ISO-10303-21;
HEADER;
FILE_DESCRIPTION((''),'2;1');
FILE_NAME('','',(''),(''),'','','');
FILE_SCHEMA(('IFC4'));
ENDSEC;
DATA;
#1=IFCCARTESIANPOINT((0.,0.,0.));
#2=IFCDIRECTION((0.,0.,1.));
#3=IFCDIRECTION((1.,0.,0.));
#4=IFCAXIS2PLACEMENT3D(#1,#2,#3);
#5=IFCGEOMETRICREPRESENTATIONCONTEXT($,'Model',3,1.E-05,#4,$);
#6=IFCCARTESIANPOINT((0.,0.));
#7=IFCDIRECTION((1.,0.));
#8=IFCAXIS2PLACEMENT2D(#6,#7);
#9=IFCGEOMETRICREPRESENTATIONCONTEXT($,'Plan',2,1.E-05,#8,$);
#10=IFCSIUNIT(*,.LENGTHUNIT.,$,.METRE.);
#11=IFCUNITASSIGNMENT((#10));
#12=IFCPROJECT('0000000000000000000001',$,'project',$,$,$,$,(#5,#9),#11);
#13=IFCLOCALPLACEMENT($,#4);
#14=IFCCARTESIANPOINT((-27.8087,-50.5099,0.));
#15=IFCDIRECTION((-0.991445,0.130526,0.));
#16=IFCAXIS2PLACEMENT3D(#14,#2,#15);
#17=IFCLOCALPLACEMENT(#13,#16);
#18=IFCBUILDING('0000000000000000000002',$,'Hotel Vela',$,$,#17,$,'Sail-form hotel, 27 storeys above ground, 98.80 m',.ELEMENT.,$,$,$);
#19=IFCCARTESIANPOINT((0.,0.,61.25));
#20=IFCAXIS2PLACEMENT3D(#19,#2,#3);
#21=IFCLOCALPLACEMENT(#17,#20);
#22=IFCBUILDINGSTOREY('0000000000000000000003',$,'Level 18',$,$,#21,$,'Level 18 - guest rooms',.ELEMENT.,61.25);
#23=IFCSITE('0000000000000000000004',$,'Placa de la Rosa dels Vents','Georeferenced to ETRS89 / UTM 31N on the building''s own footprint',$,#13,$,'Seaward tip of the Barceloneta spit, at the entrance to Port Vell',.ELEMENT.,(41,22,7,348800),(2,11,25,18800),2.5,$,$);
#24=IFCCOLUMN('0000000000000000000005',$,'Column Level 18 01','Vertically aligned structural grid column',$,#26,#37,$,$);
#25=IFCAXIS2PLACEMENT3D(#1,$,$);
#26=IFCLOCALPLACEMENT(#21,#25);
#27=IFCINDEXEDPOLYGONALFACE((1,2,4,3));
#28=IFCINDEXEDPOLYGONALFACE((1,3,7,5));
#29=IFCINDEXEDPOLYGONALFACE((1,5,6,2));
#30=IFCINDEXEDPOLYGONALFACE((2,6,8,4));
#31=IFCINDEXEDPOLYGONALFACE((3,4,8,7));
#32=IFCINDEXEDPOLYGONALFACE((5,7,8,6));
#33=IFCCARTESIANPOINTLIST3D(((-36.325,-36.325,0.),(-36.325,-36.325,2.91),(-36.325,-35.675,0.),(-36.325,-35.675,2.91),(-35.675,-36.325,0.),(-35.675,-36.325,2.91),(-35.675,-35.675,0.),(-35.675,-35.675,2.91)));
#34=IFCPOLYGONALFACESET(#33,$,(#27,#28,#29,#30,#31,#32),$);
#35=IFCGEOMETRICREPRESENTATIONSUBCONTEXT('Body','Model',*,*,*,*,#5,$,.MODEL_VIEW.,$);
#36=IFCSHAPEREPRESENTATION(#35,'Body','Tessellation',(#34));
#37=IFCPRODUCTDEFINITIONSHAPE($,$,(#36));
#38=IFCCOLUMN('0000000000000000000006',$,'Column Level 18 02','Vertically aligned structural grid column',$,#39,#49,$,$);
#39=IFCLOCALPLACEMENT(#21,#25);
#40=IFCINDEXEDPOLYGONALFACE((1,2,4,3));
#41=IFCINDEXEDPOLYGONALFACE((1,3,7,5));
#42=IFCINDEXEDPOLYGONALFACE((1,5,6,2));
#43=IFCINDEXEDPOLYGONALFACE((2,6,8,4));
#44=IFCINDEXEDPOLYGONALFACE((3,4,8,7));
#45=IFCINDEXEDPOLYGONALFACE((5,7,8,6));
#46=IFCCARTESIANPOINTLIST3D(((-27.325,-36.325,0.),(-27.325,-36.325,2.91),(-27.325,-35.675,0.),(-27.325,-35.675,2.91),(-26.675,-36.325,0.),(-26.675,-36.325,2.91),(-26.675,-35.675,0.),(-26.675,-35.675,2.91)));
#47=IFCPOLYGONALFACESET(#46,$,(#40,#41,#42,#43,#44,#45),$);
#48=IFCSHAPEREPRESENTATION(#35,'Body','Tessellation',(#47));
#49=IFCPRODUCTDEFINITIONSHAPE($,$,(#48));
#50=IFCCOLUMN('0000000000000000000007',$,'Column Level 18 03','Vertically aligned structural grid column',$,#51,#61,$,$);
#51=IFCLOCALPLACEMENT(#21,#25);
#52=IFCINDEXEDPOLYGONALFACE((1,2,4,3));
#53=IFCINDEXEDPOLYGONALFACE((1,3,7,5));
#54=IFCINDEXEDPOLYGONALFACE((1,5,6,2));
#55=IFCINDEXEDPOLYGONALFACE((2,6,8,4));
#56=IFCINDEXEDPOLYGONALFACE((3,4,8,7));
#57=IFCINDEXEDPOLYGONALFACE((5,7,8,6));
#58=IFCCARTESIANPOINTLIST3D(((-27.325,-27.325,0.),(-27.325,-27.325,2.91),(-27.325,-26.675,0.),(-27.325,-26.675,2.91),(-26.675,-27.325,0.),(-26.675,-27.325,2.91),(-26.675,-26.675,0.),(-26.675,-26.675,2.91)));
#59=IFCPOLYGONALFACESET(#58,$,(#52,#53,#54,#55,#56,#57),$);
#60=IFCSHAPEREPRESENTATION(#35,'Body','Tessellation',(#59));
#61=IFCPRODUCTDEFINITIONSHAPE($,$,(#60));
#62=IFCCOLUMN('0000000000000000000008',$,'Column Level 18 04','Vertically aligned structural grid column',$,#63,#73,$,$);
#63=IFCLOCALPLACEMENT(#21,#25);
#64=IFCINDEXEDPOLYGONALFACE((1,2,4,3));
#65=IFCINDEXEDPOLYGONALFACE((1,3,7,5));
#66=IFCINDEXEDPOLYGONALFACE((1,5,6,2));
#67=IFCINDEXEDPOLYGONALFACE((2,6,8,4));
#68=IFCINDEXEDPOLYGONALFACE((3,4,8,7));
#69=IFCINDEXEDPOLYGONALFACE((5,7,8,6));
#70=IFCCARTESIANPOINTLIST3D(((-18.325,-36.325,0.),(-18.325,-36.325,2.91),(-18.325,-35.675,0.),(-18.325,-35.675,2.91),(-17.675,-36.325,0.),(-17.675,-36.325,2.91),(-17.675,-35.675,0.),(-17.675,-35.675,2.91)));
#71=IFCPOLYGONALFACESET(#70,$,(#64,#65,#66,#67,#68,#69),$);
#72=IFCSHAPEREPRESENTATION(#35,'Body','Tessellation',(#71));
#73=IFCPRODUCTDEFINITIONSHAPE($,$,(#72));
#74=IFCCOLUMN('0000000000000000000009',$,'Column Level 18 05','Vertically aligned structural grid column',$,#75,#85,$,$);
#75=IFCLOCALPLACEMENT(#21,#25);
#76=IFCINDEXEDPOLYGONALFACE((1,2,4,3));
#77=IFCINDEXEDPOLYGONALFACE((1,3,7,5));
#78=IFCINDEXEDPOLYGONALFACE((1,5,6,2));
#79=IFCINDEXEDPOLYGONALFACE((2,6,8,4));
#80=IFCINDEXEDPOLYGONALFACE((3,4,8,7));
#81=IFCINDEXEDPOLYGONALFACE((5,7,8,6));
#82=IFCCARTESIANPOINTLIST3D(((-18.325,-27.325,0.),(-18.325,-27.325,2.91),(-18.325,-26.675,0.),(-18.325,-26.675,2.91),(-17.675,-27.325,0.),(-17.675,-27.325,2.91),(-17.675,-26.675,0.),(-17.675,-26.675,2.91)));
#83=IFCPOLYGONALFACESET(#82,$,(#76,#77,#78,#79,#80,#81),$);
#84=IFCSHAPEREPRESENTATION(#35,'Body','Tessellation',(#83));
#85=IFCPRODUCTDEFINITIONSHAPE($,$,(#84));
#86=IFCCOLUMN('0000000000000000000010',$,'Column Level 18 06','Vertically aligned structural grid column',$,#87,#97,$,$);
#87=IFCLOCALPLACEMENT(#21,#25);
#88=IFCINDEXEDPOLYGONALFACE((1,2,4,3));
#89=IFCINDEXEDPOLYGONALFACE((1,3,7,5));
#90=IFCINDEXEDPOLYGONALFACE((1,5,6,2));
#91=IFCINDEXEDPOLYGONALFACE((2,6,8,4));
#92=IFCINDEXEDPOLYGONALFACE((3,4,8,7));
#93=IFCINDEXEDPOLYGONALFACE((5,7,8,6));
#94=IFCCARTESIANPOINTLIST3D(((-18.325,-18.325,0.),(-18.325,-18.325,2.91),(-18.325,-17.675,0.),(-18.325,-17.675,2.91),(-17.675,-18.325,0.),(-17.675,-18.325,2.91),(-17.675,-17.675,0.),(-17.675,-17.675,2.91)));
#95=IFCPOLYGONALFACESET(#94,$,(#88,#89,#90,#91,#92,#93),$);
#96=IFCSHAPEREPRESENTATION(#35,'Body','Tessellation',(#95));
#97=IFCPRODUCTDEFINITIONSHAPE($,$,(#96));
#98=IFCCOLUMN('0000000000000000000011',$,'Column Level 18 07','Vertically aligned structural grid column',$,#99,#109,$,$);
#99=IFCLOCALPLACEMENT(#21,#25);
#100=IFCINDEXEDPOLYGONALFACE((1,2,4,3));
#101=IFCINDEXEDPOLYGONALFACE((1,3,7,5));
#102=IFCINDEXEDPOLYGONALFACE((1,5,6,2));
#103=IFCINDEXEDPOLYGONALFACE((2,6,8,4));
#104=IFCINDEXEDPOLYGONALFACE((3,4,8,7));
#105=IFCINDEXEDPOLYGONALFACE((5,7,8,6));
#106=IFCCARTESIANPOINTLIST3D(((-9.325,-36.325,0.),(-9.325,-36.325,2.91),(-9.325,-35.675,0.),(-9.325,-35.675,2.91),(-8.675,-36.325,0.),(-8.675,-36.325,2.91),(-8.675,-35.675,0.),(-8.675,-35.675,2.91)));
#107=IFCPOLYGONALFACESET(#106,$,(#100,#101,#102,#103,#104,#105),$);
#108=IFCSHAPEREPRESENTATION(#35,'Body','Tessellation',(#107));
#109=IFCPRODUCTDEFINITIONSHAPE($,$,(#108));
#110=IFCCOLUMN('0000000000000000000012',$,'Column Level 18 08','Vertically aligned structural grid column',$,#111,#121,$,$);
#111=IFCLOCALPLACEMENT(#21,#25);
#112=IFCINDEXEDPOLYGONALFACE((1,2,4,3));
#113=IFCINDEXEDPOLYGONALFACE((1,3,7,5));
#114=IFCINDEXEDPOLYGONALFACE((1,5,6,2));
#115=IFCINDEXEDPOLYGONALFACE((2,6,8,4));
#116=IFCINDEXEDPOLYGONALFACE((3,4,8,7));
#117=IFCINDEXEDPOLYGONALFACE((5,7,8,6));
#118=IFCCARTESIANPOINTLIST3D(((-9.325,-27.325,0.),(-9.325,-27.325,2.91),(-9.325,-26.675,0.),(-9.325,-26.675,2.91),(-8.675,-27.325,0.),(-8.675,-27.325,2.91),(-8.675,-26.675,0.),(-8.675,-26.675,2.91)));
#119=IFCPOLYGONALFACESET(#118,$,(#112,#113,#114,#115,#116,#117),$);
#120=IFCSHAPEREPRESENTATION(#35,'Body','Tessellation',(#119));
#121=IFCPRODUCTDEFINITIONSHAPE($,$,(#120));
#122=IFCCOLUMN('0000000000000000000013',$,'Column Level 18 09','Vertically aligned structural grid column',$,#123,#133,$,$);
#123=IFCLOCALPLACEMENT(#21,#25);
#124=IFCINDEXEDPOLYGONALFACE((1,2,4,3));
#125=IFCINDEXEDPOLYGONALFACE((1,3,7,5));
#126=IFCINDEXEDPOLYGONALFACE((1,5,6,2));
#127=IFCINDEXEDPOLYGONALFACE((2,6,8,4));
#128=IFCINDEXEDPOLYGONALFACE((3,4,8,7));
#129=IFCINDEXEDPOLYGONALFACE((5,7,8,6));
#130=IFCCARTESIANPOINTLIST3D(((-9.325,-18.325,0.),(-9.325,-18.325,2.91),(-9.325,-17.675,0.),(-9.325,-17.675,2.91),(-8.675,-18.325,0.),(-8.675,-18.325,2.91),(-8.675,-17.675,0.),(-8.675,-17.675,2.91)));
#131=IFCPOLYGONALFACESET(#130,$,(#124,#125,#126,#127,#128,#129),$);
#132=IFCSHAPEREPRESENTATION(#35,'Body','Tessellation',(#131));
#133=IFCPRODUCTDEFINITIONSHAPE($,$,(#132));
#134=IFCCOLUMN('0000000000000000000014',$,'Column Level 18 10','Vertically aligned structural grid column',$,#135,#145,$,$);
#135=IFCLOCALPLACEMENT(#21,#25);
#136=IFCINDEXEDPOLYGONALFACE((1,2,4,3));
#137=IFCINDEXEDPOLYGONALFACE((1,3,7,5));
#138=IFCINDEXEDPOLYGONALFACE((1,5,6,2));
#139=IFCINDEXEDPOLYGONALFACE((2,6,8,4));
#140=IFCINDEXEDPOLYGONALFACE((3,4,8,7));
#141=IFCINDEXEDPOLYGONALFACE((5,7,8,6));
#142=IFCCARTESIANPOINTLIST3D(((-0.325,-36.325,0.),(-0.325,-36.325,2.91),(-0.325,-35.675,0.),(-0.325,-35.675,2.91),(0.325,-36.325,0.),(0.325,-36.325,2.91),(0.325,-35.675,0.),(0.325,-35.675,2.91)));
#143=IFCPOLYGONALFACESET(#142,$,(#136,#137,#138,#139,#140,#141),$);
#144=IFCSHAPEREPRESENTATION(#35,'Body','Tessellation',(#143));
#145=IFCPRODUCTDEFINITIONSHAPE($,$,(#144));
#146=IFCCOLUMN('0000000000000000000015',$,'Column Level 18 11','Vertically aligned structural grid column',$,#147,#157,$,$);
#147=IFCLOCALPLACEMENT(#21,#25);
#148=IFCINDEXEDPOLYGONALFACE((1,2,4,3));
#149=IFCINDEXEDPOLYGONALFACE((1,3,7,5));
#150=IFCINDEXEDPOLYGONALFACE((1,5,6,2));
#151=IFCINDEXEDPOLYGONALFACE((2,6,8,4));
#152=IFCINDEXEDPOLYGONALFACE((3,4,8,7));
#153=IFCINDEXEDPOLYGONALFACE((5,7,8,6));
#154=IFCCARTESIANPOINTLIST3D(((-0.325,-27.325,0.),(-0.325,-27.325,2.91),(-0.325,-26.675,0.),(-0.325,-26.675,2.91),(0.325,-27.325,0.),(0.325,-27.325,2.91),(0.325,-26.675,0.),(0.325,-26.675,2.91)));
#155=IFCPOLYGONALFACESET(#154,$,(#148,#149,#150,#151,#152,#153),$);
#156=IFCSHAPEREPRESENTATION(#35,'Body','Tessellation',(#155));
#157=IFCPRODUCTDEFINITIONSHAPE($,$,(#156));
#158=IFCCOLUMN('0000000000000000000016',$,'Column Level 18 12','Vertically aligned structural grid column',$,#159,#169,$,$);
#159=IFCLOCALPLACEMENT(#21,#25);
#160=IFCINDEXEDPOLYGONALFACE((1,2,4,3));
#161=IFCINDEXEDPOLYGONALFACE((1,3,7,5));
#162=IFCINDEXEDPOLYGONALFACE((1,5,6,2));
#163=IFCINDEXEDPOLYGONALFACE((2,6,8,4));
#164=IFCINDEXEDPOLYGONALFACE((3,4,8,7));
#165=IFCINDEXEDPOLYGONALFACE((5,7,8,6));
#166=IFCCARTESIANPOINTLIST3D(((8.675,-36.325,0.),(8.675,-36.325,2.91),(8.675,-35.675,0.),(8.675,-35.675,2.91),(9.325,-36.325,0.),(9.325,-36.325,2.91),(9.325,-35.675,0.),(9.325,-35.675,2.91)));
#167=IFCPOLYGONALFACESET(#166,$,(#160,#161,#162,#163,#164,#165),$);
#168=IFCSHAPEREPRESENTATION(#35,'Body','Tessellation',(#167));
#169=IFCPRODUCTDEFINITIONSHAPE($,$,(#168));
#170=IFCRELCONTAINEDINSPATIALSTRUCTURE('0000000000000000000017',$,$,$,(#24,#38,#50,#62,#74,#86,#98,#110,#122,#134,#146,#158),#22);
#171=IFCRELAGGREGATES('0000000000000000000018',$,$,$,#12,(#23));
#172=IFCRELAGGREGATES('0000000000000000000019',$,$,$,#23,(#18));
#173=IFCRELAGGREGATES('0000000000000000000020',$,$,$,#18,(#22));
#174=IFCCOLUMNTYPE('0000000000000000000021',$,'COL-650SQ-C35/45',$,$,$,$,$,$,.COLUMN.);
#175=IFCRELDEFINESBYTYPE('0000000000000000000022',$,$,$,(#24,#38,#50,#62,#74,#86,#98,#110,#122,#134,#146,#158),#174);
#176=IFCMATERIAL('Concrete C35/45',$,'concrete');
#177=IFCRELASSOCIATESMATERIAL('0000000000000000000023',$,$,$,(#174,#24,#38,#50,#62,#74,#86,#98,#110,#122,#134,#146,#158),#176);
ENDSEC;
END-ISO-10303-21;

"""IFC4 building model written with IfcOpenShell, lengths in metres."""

from ifc_helpers import new_model, si_unit, frame, origin_with_axes, origin_2d_with_axis, place, context, subcontext, project, spatial, line, indexed_curve, rectangle, outline, extrude, material, material_profile, profile_set, profile_usage, type_object, element, save


model = new_model("IFC4")

# Units and contexts
model_context = context("Model", 3, precision=1e-05, world=origin_with_axes())
plan_context = context("Plan", 2, precision=1e-05, world=origin_2d_with_axis())
body_context = subcontext(model_context, "Body", "Model", "MODEL_VIEW")
ifc_project = project(units=[si_unit("LENGTHUNIT", "METRE")], contexts=[model_context, plan_context])

# Site, building, storey
site_placement = place(None, origin_with_axes())
site = spatial("IfcSite", under=ifc_project, at=site_placement, Name="Placa de la Rosa dels Vents", Description="Georeferenced to ETRS89 / UTM 31N on the building's own footprint", LongName="Seaward tip of the Barceloneta spit, at the entrance to Port Vell", CompositionType="ELEMENT", RefLatitude=(41, 22, 7, 348800), RefLongitude=(2, 11, 25, 18800), RefElevation=2.5)
building_placement = place(site_placement, frame((-27.8087, -50.5099, 0.0), z_axis=(0.0, 0.0, 1.0), x_axis=(-0.991445, 0.130526, 0.0)))
building = spatial("IfcBuilding", under=site, at=building_placement, Name="Hotel Vela", LongName="Sail-form hotel, 27 storeys above ground, 98.80 m", CompositionType="ELEMENT")
storey_placement = place(building_placement, frame((0.0, 0.0, 61.25), z_axis=(0.0, 0.0, 1.0), x_axis=(1.0, 0.0, 0.0)))
storey = spatial("IfcBuildingStorey", under=building, at=storey_placement, Name="Level 18", LongName="Level 18 - guest rooms", CompositionType="ELEMENT", Elevation=61.25)

# Columns
ifc_material = material(Name="Concrete C35/45", Category="concrete")
ifc_material_profile = material_profile(ifc_material, rectangle(XDim=0.65, YDim=0.65))
ifc_profile_set = profile_set([ifc_material_profile], Name="COL-650SQ-C35/45")
ifc_profile_usage_1 = profile_usage(ifc_profile_set)
column_type = type_object("IfcColumnType", Name="COL-650SQ-C35/45", PredefinedType="COLUMN", material=ifc_profile_set)
column_1_placement = place(storey_placement, frame((-36.325, -36.325, 0.0), z_axis=(0.0, 0.0, 1.0), x_axis=(1.0, 0.0, 0.0)))
element("IfcColumn", 1, at=column_1_placement, inside=storey, type_object=column_type, material=ifc_profile_usage_1, Name="Column Level 18 01", Description="Vertically aligned structural grid column", context=body_context, shape_type="SweptSolid", body=[
    extrude(outline(indexed_curve([(0.0, 0.0), (0.65, 0.0), (0.65, 0.65), (0.0, 0.65)], segments=[line(1, 2, 3, 4, 1)])), origin_with_axes(), (0.0, 0.0, 1.0), 2.91),
])
ifc_profile_usage_2 = profile_usage(ifc_profile_set)
column_2_placement = place(storey_placement, frame((-27.325, -36.325, 0.0), z_axis=(0.0, 0.0, 1.0), x_axis=(1.0, 0.0, 0.0)))
element("IfcColumn", 2, at=column_2_placement, inside=storey, type_object=column_type, material=ifc_profile_usage_2, Name="Column Level 18 02", Description="Vertically aligned structural grid column", context=body_context, shape_type="SweptSolid", body=[
    extrude(outline(indexed_curve([(0.0, 0.0), (0.65, 0.0), (0.65, 0.65), (0.0, 0.65)], segments=[line(1, 2, 3, 4, 1)])), origin_with_axes(), (0.0, 0.0, 1.0), 2.91),
])
ifc_profile_usage_3 = profile_usage(ifc_profile_set)
column_3_placement = place(storey_placement, frame((-27.325, -27.325, 0.0), z_axis=(0.0, 0.0, 1.0), x_axis=(1.0, 0.0, 0.0)))
element("IfcColumn", 3, at=column_3_placement, inside=storey, type_object=column_type, material=ifc_profile_usage_3, Name="Column Level 18 03", Description="Vertically aligned structural grid column", context=body_context, shape_type="SweptSolid", body=[
    extrude(outline(indexed_curve([(0.0, 0.0), (0.65, 0.0), (0.65, 0.65), (0.0, 0.65)], segments=[line(1, 2, 3, 4, 1)])), origin_with_axes(), (0.0, 0.0, 1.0), 2.91),
])
ifc_profile_usage_4 = profile_usage(ifc_profile_set)
column_4_placement = place(storey_placement, frame((-18.325, -36.325, 0.0), z_axis=(0.0, 0.0, 1.0), x_axis=(1.0, 0.0, 0.0)))
element("IfcColumn", 4, at=column_4_placement, inside=storey, type_object=column_type, material=ifc_profile_usage_4, Name="Column Level 18 04", Description="Vertically aligned structural grid column", context=body_context, shape_type="SweptSolid", body=[
    extrude(outline(indexed_curve([(0.0, 0.0), (0.65, 0.0), (0.65, 0.65), (0.0, 0.65)], segments=[line(1, 2, 3, 4, 1)])), origin_with_axes(), (0.0, 0.0, 1.0), 2.91),
])
ifc_profile_usage_5 = profile_usage(ifc_profile_set)
column_5_placement = place(storey_placement, frame((-18.325, -27.325, 0.0), z_axis=(0.0, 0.0, 1.0), x_axis=(1.0, 0.0, 0.0)))
element("IfcColumn", 5, at=column_5_placement, inside=storey, type_object=column_type, material=ifc_profile_usage_5, Name="Column Level 18 05", Description="Vertically aligned structural grid column", context=body_context, shape_type="SweptSolid", body=[
    extrude(outline(indexed_curve([(0.0, 0.0), (0.65, 0.0), (0.65, 0.65), (0.0, 0.65)], segments=[line(1, 2, 3, 4, 1)])), origin_with_axes(), (0.0, 0.0, 1.0), 2.91),
])
ifc_profile_usage_6 = profile_usage(ifc_profile_set)
column_6_placement = place(storey_placement, frame((-18.325, -18.325, 0.0), z_axis=(0.0, 0.0, 1.0), x_axis=(1.0, 0.0, 0.0)))
element("IfcColumn", 6, at=column_6_placement, inside=storey, type_object=column_type, material=ifc_profile_usage_6, Name="Column Level 18 06", Description="Vertically aligned structural grid column", context=body_context, shape_type="SweptSolid", body=[
    extrude(outline(indexed_curve([(0.0, 0.0), (0.65, 0.0), (0.65, 0.65), (0.0, 0.65)], segments=[line(1, 2, 3, 4, 1)])), origin_with_axes(), (0.0, 0.0, 1.0), 2.91),
])
ifc_profile_usage_7 = profile_usage(ifc_profile_set)
column_7_placement = place(storey_placement, frame((-9.325, -36.325, 0.0), z_axis=(0.0, 0.0, 1.0), x_axis=(1.0, 0.0, 0.0)))
element("IfcColumn", 7, at=column_7_placement, inside=storey, type_object=column_type, material=ifc_profile_usage_7, Name="Column Level 18 07", Description="Vertically aligned structural grid column", context=body_context, shape_type="SweptSolid", body=[
    extrude(outline(indexed_curve([(0.0, 0.0), (0.65, 0.0), (0.65, 0.65), (0.0, 0.65)], segments=[line(1, 2, 3, 4, 1)])), origin_with_axes(), (0.0, 0.0, 1.0), 2.91),
])
ifc_profile_usage_8 = profile_usage(ifc_profile_set)
column_8_placement = place(storey_placement, frame((-9.325, -27.325, 0.0), z_axis=(0.0, 0.0, 1.0), x_axis=(1.0, 0.0, 0.0)))
element("IfcColumn", 8, at=column_8_placement, inside=storey, type_object=column_type, material=ifc_profile_usage_8, Name="Column Level 18 08", Description="Vertically aligned structural grid column", context=body_context, shape_type="SweptSolid", body=[
    extrude(outline(indexed_curve([(0.0, 0.0), (0.65, 0.0), (0.65, 0.65), (0.0, 0.65)], segments=[line(1, 2, 3, 4, 1)])), origin_with_axes(), (0.0, 0.0, 1.0), 2.91),
])
ifc_profile_usage_9 = profile_usage(ifc_profile_set)
column_9_placement = place(storey_placement, frame((-9.325, -18.325, 0.0), z_axis=(0.0, 0.0, 1.0), x_axis=(1.0, 0.0, 0.0)))
element("IfcColumn", 9, at=column_9_placement, inside=storey, type_object=column_type, material=ifc_profile_usage_9, Name="Column Level 18 09", Description="Vertically aligned structural grid column", context=body_context, shape_type="SweptSolid", body=[
    extrude(outline(indexed_curve([(0.0, 0.0), (0.65, 0.0), (0.65, 0.65), (0.0, 0.65)], segments=[line(1, 2, 3, 4, 1)])), origin_with_axes(), (0.0, 0.0, 1.0), 2.91),
])
ifc_profile_usage_10 = profile_usage(ifc_profile_set)
column_10_placement = place(storey_placement, frame((-0.325, -36.325, 0.0), z_axis=(0.0, 0.0, 1.0), x_axis=(1.0, 0.0, 0.0)))
element("IfcColumn", 10, at=column_10_placement, inside=storey, type_object=column_type, material=ifc_profile_usage_10, Name="Column Level 18 10", Description="Vertically aligned structural grid column", context=body_context, shape_type="SweptSolid", body=[
    extrude(outline(indexed_curve([(0.0, 0.0), (0.65, 0.0), (0.65, 0.65), (0.0, 0.65)], segments=[line(1, 2, 3, 4, 1)])), origin_with_axes(), (0.0, 0.0, 1.0), 2.91),
])
ifc_profile_usage_11 = profile_usage(ifc_profile_set)
column_11_placement = place(storey_placement, frame((-0.325, -27.325, 0.0), z_axis=(0.0, 0.0, 1.0), x_axis=(1.0, 0.0, 0.0)))
element("IfcColumn", 11, at=column_11_placement, inside=storey, type_object=column_type, material=ifc_profile_usage_11, Name="Column Level 18 11", Description="Vertically aligned structural grid column", context=body_context, shape_type="SweptSolid", body=[
    extrude(outline(indexed_curve([(0.0, 0.0), (0.65, 0.0), (0.65, 0.65), (0.0, 0.65)], segments=[line(1, 2, 3, 4, 1)])), origin_with_axes(), (0.0, 0.0, 1.0), 2.91),
])
ifc_profile_usage_12 = profile_usage(ifc_profile_set)
column_12_placement = place(storey_placement, frame((8.675, -36.325, 0.0), z_axis=(0.0, 0.0, 1.0), x_axis=(1.0, 0.0, 0.0)))
element("IfcColumn", 12, at=column_12_placement, inside=storey, type_object=column_type, material=ifc_profile_usage_12, Name="Column Level 18 12", Description="Vertically aligned structural grid column", context=body_context, shape_type="SweptSolid", body=[
    extrude(outline(indexed_curve([(0.0, 0.0), (0.65, 0.0), (0.65, 0.65), (0.0, 0.65)], segments=[line(1, 2, 3, 4, 1)])), origin_with_axes(), (0.0, 0.0, 1.0), 2.91),
])

save(model, "model.ifc")
